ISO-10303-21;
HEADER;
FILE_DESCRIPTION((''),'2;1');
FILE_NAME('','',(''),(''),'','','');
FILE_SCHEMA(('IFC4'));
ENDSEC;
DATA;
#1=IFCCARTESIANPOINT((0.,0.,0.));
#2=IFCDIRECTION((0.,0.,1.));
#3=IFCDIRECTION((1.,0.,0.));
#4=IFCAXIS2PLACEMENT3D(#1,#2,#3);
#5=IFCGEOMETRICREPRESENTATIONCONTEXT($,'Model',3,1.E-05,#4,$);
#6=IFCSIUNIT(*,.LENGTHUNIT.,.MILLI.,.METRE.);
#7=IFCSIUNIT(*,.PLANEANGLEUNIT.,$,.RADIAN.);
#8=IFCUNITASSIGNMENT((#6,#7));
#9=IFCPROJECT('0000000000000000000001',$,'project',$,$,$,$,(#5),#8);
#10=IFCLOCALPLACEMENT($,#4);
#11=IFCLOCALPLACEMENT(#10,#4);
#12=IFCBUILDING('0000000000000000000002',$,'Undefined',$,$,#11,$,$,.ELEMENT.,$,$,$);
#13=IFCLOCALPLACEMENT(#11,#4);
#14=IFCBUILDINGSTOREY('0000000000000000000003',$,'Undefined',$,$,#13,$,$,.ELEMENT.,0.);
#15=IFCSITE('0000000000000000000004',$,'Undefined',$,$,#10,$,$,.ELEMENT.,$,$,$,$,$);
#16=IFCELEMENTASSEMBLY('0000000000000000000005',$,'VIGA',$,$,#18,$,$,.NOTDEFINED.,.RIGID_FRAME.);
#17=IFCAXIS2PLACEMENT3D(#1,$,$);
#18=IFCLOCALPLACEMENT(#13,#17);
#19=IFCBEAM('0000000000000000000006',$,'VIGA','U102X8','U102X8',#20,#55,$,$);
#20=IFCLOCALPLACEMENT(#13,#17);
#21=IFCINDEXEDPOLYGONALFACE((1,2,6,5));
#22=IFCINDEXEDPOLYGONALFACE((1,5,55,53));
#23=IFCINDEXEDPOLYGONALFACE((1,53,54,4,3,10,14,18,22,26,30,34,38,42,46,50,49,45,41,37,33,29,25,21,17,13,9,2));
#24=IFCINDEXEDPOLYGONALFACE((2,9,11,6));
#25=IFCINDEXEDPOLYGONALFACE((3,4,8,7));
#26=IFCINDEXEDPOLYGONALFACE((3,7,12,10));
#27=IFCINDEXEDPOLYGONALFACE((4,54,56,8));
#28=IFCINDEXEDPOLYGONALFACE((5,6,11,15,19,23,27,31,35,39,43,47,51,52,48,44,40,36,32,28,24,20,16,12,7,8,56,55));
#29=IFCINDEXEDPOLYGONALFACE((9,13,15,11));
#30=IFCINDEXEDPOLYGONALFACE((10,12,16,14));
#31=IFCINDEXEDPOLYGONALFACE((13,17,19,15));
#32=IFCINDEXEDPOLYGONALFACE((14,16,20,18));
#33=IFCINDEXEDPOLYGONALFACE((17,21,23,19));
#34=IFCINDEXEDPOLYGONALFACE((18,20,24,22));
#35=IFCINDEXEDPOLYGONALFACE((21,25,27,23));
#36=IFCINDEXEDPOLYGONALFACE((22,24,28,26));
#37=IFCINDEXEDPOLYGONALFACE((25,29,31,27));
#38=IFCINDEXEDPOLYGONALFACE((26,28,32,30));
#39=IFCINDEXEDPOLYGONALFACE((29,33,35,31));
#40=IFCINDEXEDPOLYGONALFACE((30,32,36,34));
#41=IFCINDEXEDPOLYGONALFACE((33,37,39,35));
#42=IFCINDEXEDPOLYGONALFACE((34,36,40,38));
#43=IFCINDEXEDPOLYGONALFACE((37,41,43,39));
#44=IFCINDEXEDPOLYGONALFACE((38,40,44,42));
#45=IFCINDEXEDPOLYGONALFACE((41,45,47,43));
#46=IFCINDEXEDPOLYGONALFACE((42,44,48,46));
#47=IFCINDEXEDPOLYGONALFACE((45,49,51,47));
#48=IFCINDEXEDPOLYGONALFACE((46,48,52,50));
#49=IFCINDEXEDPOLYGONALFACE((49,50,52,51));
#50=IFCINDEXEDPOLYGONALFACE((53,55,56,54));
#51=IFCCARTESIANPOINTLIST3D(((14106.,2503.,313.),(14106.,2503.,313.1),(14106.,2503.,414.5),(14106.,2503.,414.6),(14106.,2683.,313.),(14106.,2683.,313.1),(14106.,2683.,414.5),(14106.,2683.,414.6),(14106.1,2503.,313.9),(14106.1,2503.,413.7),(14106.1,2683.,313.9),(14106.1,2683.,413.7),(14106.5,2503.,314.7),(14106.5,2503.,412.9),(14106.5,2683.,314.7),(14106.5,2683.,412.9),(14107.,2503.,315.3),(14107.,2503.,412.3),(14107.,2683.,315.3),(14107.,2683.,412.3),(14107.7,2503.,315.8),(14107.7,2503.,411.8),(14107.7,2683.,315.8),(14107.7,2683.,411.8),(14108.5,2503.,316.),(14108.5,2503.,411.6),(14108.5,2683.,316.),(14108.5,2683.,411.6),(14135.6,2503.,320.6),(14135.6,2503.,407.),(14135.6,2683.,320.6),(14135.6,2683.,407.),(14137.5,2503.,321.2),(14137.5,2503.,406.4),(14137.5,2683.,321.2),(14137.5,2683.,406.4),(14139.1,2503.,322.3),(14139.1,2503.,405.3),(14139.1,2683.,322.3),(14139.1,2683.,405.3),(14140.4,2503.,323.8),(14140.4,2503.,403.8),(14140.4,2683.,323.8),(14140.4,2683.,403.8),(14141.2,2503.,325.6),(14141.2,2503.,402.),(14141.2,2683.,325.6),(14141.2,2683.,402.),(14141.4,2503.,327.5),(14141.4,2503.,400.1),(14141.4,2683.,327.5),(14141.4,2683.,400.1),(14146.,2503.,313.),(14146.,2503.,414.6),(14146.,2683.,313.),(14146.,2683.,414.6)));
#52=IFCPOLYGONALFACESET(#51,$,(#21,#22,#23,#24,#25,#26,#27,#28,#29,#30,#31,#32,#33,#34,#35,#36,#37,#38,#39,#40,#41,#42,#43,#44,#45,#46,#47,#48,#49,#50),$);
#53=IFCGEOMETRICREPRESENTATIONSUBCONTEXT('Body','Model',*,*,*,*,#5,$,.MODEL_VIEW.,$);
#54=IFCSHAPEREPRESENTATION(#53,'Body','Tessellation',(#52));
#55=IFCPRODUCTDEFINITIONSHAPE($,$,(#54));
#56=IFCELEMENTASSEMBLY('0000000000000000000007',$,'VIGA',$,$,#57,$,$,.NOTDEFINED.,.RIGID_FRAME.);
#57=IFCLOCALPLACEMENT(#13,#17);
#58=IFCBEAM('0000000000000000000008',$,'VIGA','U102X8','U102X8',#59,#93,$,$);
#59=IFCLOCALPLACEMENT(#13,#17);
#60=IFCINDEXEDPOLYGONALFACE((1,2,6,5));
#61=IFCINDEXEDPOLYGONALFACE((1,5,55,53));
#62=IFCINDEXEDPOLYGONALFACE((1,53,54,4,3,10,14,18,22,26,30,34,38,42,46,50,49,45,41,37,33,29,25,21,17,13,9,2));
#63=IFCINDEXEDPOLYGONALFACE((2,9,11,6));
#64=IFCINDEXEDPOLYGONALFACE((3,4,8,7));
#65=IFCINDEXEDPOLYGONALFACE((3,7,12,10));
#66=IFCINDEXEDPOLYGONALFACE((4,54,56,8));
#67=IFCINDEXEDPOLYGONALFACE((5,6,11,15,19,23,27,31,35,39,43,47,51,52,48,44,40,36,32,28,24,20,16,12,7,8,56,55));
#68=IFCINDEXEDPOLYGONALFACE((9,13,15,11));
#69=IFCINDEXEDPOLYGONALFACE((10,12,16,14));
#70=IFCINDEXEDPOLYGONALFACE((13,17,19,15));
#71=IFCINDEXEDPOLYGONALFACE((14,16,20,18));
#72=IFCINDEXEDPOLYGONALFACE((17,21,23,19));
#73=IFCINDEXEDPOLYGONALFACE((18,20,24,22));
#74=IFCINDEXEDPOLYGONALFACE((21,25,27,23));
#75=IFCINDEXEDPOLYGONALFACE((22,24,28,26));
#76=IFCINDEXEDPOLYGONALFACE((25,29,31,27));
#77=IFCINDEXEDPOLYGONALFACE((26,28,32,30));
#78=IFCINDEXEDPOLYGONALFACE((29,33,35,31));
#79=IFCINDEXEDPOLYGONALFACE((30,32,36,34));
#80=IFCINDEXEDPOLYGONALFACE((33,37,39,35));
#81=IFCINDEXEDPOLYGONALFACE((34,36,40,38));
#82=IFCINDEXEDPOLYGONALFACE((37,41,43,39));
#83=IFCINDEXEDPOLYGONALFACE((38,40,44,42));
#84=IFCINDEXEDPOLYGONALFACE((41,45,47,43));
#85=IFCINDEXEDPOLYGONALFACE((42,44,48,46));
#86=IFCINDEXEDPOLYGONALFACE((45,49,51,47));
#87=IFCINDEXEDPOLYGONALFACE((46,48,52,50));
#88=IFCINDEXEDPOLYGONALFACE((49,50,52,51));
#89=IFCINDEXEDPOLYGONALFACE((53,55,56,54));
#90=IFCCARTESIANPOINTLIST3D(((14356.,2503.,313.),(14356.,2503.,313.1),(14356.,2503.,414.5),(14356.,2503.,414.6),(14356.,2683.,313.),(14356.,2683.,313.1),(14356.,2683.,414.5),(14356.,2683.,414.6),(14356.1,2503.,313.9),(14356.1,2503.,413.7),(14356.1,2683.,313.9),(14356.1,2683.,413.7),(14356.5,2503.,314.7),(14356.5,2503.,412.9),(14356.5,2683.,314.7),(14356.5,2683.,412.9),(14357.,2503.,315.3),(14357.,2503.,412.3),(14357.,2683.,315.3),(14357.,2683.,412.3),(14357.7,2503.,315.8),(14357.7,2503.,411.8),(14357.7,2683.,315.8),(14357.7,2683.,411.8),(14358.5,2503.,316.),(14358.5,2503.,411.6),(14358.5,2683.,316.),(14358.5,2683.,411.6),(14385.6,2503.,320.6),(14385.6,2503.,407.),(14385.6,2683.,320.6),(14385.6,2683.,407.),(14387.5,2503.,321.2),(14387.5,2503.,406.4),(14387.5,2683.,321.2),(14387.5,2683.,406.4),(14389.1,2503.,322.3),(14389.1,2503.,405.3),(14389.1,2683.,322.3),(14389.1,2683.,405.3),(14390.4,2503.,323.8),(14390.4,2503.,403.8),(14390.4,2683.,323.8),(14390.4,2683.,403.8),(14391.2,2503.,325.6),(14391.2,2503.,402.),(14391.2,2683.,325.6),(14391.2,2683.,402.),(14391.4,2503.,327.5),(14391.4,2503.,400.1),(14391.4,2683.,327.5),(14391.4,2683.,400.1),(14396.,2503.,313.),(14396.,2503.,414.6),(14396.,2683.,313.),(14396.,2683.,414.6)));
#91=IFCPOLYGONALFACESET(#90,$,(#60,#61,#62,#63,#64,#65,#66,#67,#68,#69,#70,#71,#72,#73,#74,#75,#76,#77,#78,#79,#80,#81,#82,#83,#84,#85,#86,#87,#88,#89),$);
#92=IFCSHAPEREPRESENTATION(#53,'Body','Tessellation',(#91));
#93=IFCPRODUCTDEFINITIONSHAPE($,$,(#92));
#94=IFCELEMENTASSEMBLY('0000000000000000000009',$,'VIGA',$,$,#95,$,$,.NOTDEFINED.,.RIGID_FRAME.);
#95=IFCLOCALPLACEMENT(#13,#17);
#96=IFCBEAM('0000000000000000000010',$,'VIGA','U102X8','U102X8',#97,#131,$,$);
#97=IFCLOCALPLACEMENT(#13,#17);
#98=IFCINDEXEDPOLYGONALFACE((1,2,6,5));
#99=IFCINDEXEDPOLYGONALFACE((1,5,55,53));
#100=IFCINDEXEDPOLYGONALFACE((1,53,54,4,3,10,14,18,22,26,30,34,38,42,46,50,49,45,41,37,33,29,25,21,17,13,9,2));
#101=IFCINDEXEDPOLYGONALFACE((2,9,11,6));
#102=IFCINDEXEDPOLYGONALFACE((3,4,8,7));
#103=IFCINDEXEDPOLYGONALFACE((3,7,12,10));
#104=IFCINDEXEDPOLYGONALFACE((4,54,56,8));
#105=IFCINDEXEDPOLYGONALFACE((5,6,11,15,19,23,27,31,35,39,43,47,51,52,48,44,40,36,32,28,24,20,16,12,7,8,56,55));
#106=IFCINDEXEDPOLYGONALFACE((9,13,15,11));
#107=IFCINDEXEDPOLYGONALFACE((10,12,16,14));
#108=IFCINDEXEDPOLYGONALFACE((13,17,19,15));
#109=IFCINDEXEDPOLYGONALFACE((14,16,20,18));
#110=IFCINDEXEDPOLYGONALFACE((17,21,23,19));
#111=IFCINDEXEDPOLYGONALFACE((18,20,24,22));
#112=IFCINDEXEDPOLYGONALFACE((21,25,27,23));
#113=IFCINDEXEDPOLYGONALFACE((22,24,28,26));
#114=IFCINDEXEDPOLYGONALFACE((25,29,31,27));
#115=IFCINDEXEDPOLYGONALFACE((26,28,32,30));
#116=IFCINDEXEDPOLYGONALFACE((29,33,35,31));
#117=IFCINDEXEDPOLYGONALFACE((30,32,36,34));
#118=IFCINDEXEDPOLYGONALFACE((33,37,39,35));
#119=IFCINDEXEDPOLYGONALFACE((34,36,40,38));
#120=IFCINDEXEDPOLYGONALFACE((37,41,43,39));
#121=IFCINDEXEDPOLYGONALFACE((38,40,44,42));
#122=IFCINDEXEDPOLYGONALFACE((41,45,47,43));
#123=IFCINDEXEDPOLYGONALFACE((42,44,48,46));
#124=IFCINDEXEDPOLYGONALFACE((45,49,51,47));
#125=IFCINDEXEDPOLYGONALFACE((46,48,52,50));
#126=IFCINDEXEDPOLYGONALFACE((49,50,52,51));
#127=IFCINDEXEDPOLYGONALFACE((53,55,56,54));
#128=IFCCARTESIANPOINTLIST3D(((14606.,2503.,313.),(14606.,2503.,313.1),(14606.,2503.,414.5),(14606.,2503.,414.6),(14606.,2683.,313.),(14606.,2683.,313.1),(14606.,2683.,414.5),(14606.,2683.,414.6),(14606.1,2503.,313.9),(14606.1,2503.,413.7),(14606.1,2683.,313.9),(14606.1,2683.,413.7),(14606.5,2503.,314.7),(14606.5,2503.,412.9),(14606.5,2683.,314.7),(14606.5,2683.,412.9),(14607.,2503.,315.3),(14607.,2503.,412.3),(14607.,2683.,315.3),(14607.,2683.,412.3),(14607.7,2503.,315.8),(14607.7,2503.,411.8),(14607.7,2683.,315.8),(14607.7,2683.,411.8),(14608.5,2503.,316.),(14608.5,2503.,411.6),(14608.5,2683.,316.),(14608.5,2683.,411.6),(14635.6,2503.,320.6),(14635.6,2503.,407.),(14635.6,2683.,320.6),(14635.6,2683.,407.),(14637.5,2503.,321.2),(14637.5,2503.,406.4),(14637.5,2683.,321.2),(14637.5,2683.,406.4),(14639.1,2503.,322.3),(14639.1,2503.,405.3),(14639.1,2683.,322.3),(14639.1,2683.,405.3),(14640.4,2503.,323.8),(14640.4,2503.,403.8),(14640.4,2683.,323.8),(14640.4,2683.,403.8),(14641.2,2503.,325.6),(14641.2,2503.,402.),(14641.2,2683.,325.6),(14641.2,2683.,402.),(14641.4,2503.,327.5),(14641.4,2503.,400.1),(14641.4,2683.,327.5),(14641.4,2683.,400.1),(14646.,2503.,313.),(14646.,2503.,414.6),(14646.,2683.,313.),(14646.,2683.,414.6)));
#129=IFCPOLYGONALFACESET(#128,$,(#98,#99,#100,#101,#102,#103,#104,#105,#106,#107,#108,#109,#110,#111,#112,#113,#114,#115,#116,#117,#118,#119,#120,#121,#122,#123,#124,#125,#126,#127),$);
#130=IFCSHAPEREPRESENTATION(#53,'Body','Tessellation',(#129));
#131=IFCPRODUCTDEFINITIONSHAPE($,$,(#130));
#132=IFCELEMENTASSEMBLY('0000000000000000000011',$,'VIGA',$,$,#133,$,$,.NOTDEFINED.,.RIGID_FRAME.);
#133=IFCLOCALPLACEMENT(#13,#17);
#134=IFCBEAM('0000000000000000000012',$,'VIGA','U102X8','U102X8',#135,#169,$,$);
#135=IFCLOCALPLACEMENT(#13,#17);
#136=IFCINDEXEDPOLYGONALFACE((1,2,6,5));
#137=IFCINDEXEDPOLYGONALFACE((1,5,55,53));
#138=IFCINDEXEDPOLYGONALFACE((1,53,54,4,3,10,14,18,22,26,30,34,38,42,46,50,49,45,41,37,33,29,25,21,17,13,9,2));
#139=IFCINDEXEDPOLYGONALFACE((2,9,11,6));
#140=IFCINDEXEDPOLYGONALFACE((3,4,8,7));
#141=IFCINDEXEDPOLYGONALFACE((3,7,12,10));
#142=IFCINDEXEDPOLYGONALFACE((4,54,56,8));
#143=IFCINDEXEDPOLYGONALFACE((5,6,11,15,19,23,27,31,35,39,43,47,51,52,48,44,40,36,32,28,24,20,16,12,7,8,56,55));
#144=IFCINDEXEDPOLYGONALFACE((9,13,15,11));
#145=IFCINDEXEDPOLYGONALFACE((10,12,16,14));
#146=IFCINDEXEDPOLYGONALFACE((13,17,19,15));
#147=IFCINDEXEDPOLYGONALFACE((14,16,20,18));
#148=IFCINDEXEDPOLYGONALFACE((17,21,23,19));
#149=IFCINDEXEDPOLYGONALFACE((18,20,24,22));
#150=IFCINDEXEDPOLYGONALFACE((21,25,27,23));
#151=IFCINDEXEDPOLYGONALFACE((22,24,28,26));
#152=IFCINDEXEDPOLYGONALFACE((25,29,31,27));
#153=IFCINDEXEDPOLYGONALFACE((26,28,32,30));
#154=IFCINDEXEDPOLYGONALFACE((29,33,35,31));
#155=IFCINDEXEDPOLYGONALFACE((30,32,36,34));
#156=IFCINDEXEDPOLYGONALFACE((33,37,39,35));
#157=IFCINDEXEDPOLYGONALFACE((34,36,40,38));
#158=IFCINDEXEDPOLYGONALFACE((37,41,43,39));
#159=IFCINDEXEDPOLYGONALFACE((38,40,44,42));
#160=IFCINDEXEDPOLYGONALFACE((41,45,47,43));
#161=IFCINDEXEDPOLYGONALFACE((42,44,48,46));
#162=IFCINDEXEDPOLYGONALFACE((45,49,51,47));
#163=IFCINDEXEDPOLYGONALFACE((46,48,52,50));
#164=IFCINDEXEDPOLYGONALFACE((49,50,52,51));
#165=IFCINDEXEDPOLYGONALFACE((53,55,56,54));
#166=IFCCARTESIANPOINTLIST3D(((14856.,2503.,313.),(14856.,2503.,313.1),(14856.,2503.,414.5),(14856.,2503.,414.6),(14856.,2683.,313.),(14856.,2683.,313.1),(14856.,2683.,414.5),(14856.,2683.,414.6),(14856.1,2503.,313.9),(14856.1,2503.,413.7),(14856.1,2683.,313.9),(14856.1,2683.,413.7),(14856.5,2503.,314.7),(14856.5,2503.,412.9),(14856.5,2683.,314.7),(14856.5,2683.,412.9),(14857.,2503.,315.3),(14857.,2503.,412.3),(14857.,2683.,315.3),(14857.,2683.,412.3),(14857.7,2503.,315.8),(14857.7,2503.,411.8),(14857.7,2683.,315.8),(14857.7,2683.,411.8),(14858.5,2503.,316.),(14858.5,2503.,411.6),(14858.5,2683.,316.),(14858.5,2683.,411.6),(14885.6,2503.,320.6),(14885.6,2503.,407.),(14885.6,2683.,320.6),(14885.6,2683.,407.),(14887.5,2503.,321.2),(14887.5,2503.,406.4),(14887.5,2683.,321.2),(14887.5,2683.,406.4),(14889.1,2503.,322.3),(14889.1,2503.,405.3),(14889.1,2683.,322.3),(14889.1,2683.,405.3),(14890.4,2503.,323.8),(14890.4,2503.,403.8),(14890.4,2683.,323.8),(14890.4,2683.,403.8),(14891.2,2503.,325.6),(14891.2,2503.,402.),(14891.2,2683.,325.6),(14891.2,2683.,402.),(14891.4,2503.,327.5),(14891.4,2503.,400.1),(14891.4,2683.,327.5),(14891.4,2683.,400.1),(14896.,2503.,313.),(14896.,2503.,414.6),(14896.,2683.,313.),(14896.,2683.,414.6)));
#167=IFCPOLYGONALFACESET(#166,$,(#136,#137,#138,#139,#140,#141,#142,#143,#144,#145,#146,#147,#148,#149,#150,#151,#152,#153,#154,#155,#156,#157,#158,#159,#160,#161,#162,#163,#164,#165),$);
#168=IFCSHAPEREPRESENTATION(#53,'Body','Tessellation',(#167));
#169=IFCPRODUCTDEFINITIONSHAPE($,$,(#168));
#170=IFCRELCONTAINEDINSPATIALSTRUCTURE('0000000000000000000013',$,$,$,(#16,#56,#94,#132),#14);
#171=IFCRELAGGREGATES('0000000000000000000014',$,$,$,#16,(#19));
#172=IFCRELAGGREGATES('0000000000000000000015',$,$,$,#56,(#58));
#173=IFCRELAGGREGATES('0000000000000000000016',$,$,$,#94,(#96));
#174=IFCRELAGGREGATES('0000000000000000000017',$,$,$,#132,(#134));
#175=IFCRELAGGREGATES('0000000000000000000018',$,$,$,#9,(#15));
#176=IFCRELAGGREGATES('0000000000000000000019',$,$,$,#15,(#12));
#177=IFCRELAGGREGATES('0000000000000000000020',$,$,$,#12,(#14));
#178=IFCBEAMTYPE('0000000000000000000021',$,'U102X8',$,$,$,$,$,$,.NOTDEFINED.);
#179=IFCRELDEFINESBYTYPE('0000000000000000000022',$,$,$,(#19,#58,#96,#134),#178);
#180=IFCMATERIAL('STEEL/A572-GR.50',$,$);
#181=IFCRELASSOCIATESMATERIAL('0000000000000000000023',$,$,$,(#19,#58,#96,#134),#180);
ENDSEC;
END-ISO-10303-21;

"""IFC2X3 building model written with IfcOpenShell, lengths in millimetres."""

from ifc_helpers import new_model, si_unit, frame, origin_with_axes, origin_2d_with_axis, place, context, subcontext, project, spatial, u_section, extrude, material, type_object, element, aggregate, save


model = new_model("IFC2X3")

# Units and contexts
model_context = context("Model", 3, precision=1e-05, world=origin_with_axes())
body_context = subcontext(model_context, "Body", "Model", "MODEL_VIEW")
ifc_project = project(units=[si_unit("LENGTHUNIT", "METRE", prefix="MILLI"), si_unit("PLANEANGLEUNIT", "RADIAN")], contexts=[model_context])

# Site, building, storey
site_placement = place(None, origin_with_axes())
site = spatial("IfcSite", under=ifc_project, at=site_placement, Name="Undefined", CompositionType="ELEMENT")
building_placement = place(site_placement, origin_with_axes())
building = spatial("IfcBuilding", under=site, at=building_placement, Name="Undefined", CompositionType="ELEMENT")
storey_placement = place(building_placement, origin_with_axes())
storey = spatial("IfcBuildingStorey", under=building, at=storey_placement, Name="Undefined", CompositionType="ELEMENT", Elevation=0.0)

# Element assemblies, beams
ifc_material_1 = material(Name="STEEL/A572-GR.50")
beam_type_1 = type_object("IfcBeamType", Name="U102X8", PredefinedType="NOTDEFINED")
assembly_1_placement = place(storey_placement, origin_with_axes())
assembly_1 = element("IfcElementAssembly", 1, at=assembly_1_placement, inside=storey, Name="VIGA", AssemblyPlace="NOTDEFINED", PredefinedType="RIGID_FRAME")
beam_1_placement = place(assembly_1_placement, frame((14126.0, 2683.0, 363.8), z_axis=(0.0, 0.0, 1.0), x_axis=(0.0, -1.0, 0.0)))
beam_1 = element("IfcBeam", 2, at=beam_1_placement, type_object=beam_type_1, material=ifc_material_1, Name="VIGA", Description="U102X8", ObjectType="U102X8", context=body_context, shape_type="SweptSolid", body=[
    extrude(u_section(Depth=101.6, FlangeWidth=40.0, WebThickness=4.6, FlangeThickness=6.0, FilletRadius=7.0, EdgeRadius=3.0, FlangeSlope=0.16839, at=origin_2d_with_axis()), frame((180.0, 0.0, 0.0), z_axis=(-1.0, 0.0, 0.0), x_axis=(0.0, -1.0, 0.0)), (0.0, 0.0, 1.0), 180.0),
])
aggregate(assembly_1, [beam_1])
assembly_2_placement = place(storey_placement, origin_with_axes())
assembly_2 = element("IfcElementAssembly", 3, at=assembly_2_placement, inside=storey, Name="VIGA", AssemblyPlace="NOTDEFINED", PredefinedType="RIGID_FRAME")
beam_2_placement = place(assembly_2_placement, frame((14376.0, 2683.0, 363.8), z_axis=(0.0, 0.0, 1.0), x_axis=(0.0, -1.0, 0.0)))
beam_2 = element("IfcBeam", 4, at=beam_2_placement, type_object=beam_type_1, material=ifc_material_1, Name="VIGA", Description="U102X8", ObjectType="U102X8", context=body_context, shape_type="SweptSolid", body=[
    extrude(u_section(Depth=101.6, FlangeWidth=40.0, WebThickness=4.6, FlangeThickness=6.0, FilletRadius=7.0, EdgeRadius=3.0, FlangeSlope=0.16839, at=origin_2d_with_axis()), frame((180.0, 0.0, 0.0), z_axis=(-1.0, 0.0, 0.0), x_axis=(0.0, -1.0, 0.0)), (0.0, 0.0, 1.0), 180.0),
])
aggregate(assembly_2, [beam_2])
assembly_3_placement = place(storey_placement, origin_with_axes())
assembly_3 = element("IfcElementAssembly", 5, at=assembly_3_placement, inside=storey, Name="VIGA", AssemblyPlace="NOTDEFINED", PredefinedType="RIGID_FRAME")
beam_3_placement = place(assembly_3_placement, frame((14626.0, 2683.0, 363.8), z_axis=(0.0, 0.0, 1.0), x_axis=(0.0, -1.0, 0.0)))
beam_3 = element("IfcBeam", 6, at=beam_3_placement, type_object=beam_type_1, material=ifc_material_1, Name="VIGA", Description="U102X8", ObjectType="U102X8", context=body_context, shape_type="SweptSolid", body=[
    extrude(u_section(Depth=101.6, FlangeWidth=40.0, WebThickness=4.6, FlangeThickness=6.0, FilletRadius=7.0, EdgeRadius=3.0, FlangeSlope=0.16839, at=origin_2d_with_axis()), frame((180.0, 0.0, 0.0), z_axis=(-1.0, 0.0, 0.0), x_axis=(0.0, -1.0, 0.0)), (0.0, 0.0, 1.0), 180.0),
])
aggregate(assembly_3, [beam_3])
assembly_4_placement = place(storey_placement, origin_with_axes())
assembly_4 = element("IfcElementAssembly", 7, at=assembly_4_placement, inside=storey, Name="VIGA", AssemblyPlace="NOTDEFINED", PredefinedType="RIGID_FRAME")
beam_4_placement = place(assembly_4_placement, frame((14876.0, 2683.0, 363.8), z_axis=(0.0, 0.0, 1.0), x_axis=(0.0, -1.0, 0.0)))
beam_4 = element("IfcBeam", 8, at=beam_4_placement, type_object=beam_type_1, material=ifc_material_1, Name="VIGA", Description="U102X8", ObjectType="U102X8", context=body_context, shape_type="SweptSolid", body=[
    extrude(u_section(Depth=101.6, FlangeWidth=40.0, WebThickness=4.6, FlangeThickness=6.0, FilletRadius=7.0, EdgeRadius=3.0, FlangeSlope=0.16839, at=origin_2d_with_axis()), frame((180.0, 0.0, 0.0), z_axis=(-1.0, 0.0, 0.0), x_axis=(0.0, -1.0, 0.0)), (0.0, 0.0, 1.0), 180.0),
])
aggregate(assembly_4, [beam_4])

save(model, "model.ifc")
